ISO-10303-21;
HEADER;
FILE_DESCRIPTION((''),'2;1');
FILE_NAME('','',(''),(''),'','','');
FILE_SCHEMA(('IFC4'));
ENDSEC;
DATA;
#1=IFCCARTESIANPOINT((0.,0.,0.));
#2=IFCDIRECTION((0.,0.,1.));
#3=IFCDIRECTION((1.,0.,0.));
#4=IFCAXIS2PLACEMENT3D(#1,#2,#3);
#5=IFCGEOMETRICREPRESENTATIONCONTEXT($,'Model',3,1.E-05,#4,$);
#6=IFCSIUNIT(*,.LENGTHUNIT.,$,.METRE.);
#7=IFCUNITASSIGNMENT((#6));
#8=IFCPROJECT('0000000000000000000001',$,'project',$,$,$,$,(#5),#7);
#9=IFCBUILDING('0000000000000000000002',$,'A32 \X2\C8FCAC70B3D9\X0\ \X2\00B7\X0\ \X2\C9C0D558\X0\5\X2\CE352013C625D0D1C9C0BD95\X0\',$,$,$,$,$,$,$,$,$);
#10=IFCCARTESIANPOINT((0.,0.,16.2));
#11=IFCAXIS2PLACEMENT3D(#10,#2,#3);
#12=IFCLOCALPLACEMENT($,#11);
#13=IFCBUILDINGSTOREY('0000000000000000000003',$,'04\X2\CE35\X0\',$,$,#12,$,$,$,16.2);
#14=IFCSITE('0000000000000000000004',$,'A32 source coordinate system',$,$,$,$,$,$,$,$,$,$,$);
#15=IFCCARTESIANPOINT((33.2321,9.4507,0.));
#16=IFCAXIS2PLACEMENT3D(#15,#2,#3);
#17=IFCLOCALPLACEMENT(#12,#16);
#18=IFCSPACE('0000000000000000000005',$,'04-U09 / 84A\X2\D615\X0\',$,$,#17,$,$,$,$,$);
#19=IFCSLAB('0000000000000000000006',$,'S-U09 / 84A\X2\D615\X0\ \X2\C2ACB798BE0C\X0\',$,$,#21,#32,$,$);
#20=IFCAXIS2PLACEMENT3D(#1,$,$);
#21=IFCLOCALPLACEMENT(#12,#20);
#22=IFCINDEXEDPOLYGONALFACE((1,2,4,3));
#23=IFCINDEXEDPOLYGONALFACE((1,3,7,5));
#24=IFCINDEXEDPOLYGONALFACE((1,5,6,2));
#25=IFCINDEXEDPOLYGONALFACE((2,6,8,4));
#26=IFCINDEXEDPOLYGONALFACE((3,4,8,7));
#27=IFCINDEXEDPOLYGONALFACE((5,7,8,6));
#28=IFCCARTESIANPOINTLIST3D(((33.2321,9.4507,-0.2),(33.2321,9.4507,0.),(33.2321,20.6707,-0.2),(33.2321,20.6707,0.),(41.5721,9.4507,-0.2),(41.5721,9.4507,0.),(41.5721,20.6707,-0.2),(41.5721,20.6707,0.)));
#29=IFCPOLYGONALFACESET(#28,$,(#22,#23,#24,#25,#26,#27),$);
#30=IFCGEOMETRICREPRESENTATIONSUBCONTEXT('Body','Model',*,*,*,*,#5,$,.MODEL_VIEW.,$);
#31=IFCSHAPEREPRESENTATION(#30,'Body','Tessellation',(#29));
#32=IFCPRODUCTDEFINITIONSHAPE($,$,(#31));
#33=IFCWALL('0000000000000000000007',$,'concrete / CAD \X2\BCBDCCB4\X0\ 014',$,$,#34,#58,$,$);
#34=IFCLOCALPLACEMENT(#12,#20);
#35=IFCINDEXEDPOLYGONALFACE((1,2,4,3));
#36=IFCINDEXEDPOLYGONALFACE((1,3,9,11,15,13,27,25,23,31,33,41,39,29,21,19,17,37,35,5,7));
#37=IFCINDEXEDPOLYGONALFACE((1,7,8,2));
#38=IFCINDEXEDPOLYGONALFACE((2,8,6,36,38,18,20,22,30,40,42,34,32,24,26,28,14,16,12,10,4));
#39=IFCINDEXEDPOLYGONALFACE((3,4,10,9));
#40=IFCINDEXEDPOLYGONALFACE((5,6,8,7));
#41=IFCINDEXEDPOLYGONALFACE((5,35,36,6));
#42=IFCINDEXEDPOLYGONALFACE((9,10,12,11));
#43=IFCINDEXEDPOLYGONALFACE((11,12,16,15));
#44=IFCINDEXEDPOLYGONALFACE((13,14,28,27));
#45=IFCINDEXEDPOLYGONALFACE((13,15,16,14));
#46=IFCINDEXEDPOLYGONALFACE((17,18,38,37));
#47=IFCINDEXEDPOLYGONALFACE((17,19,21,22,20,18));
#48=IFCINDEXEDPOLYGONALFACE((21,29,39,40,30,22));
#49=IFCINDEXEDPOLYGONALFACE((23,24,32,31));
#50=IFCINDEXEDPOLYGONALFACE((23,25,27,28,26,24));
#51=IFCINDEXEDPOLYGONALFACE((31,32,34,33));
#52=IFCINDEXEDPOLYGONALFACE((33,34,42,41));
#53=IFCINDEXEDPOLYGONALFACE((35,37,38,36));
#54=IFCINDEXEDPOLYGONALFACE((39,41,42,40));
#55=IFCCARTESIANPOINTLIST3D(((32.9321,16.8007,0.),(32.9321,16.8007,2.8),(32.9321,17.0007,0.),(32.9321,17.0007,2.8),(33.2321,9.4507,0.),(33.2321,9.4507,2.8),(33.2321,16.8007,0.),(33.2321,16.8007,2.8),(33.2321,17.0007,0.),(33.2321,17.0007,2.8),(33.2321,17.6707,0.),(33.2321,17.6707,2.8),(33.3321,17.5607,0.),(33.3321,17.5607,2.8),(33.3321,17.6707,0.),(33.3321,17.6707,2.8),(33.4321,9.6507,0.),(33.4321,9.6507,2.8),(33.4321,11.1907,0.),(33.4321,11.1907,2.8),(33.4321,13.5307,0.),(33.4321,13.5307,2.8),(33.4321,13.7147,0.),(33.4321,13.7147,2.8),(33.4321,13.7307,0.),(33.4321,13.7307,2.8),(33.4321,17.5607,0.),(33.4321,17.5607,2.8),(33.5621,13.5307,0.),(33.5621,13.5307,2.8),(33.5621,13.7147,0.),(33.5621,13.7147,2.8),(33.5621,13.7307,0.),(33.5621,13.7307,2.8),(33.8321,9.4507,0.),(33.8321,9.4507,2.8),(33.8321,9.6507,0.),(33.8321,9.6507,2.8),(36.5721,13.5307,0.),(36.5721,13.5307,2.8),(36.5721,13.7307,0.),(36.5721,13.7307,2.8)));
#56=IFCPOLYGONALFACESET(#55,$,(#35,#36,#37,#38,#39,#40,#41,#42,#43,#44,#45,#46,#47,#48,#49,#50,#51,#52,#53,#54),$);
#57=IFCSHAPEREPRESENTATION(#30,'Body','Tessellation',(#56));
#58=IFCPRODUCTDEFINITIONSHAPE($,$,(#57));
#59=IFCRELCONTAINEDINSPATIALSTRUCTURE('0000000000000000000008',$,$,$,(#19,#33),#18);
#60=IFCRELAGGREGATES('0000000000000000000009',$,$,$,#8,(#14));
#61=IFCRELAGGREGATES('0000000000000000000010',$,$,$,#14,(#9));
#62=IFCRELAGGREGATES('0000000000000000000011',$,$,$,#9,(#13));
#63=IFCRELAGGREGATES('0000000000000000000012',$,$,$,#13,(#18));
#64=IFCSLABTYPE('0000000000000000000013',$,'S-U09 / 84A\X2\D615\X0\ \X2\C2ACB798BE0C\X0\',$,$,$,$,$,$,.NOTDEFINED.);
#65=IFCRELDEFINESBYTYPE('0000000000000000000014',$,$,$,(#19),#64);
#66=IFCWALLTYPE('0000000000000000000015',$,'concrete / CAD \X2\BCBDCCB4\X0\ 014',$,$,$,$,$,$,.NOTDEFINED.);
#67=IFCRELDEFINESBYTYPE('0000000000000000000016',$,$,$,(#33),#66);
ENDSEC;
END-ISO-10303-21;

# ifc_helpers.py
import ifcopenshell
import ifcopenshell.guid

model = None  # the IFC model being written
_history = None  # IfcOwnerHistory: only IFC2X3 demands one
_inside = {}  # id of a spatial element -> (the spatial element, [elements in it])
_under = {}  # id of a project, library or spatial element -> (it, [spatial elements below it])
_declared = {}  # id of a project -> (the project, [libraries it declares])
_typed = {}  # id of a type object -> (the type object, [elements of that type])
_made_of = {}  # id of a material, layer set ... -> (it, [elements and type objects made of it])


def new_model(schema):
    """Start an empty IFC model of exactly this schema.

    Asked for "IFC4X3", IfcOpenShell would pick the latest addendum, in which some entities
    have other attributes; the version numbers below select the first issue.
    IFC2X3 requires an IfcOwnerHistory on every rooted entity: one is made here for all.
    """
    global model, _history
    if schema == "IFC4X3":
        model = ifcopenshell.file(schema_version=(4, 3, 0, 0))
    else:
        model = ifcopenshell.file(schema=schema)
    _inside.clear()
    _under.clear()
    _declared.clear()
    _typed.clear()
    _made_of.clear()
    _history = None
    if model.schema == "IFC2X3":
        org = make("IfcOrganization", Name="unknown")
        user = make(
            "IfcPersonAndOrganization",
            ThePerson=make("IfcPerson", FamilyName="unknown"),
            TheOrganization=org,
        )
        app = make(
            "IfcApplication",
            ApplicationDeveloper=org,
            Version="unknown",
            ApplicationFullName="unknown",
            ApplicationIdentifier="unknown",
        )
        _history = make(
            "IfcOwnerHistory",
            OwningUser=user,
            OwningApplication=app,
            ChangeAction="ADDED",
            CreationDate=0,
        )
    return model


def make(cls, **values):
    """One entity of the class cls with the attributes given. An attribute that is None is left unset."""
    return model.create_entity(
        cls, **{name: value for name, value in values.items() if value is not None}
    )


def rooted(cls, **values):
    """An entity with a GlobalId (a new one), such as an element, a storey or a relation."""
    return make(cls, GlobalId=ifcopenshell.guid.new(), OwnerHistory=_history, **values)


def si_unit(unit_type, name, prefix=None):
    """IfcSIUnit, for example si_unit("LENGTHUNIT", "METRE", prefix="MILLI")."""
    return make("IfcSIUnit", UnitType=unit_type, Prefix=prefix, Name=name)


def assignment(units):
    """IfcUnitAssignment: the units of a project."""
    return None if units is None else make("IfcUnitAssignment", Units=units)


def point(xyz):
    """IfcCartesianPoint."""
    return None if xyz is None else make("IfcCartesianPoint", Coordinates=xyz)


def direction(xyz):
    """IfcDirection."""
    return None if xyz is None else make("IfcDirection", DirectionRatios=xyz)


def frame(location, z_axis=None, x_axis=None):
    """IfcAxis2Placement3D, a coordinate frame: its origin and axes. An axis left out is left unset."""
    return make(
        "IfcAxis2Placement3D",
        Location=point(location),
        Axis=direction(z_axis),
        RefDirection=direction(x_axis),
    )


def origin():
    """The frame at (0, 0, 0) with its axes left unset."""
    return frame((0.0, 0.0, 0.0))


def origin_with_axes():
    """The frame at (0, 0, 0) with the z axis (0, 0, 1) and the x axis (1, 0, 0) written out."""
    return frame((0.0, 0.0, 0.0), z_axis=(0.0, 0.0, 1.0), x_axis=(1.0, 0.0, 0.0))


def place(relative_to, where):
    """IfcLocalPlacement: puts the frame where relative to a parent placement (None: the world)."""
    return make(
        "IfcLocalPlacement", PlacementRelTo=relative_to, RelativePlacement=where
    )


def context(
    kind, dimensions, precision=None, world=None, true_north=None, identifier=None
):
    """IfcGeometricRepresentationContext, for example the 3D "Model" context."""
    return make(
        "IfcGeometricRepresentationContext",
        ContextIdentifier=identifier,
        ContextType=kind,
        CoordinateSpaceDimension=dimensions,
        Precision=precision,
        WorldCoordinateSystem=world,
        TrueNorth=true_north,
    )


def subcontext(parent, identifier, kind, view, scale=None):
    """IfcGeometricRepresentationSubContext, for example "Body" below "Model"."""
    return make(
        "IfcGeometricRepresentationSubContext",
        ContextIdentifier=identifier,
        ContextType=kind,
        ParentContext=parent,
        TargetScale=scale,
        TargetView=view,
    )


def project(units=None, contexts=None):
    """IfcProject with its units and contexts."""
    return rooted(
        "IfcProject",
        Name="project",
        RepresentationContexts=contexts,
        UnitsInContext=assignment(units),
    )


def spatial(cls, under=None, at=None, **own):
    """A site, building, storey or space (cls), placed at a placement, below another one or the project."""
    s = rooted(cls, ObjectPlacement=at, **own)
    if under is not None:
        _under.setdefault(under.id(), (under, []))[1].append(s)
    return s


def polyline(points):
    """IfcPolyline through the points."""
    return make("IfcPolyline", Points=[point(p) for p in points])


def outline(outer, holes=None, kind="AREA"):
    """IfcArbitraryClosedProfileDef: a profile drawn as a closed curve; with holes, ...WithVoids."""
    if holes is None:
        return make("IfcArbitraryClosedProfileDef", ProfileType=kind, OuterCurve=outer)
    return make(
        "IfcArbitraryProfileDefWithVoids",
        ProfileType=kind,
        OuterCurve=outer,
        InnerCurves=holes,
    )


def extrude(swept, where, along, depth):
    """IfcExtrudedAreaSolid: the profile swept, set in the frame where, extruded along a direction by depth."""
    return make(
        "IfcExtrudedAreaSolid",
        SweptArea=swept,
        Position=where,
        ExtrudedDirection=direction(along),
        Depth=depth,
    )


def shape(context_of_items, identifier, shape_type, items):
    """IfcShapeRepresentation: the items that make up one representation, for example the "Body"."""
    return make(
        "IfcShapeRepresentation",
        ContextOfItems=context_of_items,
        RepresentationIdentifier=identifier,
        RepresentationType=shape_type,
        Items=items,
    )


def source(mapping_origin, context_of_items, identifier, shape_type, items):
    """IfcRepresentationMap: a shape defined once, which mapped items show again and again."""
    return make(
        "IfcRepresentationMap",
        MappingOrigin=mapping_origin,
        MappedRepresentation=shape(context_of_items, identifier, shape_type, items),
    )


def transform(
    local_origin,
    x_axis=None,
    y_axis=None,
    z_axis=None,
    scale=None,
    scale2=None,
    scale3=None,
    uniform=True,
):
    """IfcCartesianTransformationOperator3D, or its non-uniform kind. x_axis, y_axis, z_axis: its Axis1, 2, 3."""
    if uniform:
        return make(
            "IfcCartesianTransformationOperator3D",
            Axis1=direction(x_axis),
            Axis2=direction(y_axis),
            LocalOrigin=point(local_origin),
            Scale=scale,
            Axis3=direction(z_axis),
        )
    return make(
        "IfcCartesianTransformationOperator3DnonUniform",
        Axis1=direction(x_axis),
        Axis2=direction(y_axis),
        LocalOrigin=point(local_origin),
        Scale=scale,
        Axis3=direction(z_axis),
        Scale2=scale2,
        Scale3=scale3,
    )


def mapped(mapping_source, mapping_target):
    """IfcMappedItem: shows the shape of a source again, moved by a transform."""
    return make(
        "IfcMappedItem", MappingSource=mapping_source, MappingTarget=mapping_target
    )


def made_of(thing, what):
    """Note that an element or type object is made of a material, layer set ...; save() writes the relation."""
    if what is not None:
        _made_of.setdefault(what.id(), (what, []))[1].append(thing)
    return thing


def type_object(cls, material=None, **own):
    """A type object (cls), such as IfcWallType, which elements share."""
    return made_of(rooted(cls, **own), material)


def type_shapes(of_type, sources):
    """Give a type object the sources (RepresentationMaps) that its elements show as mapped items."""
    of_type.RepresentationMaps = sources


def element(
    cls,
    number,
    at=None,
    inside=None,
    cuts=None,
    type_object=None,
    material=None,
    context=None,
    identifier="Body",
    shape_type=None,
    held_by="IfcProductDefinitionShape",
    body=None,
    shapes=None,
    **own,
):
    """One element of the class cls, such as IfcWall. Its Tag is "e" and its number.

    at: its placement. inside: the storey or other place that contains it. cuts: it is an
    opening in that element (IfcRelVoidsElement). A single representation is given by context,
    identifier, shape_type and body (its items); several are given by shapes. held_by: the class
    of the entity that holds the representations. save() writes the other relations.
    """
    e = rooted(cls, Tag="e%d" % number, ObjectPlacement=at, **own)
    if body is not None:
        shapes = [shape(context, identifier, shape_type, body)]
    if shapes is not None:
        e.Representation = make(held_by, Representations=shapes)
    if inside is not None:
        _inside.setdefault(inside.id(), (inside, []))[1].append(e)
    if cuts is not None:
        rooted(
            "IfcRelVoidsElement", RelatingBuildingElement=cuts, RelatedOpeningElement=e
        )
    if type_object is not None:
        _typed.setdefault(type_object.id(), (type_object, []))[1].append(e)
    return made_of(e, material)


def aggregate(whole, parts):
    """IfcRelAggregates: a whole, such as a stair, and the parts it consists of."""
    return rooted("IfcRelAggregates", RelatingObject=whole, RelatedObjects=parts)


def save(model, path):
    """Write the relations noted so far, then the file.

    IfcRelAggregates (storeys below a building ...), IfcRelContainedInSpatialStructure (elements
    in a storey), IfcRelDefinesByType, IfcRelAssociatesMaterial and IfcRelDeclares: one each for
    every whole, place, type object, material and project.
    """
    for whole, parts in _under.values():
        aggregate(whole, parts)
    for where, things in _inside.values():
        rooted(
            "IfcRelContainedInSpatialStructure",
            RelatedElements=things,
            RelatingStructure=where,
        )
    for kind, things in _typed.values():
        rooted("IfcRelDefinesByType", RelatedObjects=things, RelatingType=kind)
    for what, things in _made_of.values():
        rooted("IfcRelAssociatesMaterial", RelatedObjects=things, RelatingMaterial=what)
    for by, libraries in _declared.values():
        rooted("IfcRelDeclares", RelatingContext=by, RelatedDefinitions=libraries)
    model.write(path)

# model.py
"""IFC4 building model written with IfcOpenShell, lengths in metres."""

from ifc_helpers import new_model, si_unit, frame, origin, origin_with_axes, place, context, subcontext, project, spatial, polyline, outline, extrude, source, transform, mapped, type_object, type_shapes, element, save


model = new_model("IFC4")

# Units and contexts
model_context = context("Model", 3, precision=1e-05, world=origin_with_axes())
body_context = subcontext(model_context, "Body", "Model", "MODEL_VIEW")
ifc_project = project(units=[si_unit("LENGTHUNIT", "METRE")], contexts=[model_context])

# Site, building, storey, space
storey_placement = place(None, frame((0.0, 0.0, 16.2), z_axis=(0.0, 0.0, 1.0), x_axis=(1.0, 0.0, 0.0)))
space_placement = place(storey_placement, frame((33.2321, 9.4507, 0.0), z_axis=(0.0, 0.0, 1.0), x_axis=(1.0, 0.0, 0.0)))
site = spatial("IfcSite", under=ifc_project, Name="A32 source coordinate system")
building = spatial("IfcBuilding", under=site, Name="A32 주거동 · 지하5층–옥탑지붕")
storey = spatial("IfcBuildingStorey", under=building, at=storey_placement, Name="04층", Elevation=16.2)
space = spatial("IfcSpace", under=storey, at=space_placement, Name="04-U09 / 84A형")

# Slab
slab_type_1 = type_object("IfcSlabType", Name="S-U09 / 84A형 슬래브", PredefinedType="NOTDEFINED")
shared_shape_1 = source(origin(), body_context, "Body", "SweptSolid", [
    extrude(outline(polyline([(0.0, 11.22), (8.34, 11.22), (8.34, 0.0), (0.0, 0.0), (0.0, 11.22)])), frame((0.0, 0.0, -0.2)), (0.0, 0.0, 1.0), 0.2),
])
type_shapes(slab_type_1, [shared_shape_1])
slab_1_placement = place(space_placement, origin_with_axes())
element("IfcSlab", 1, at=slab_1_placement, inside=space, type_object=slab_type_1, Name="S-U09 / 84A형 슬래브", context=body_context, shape_type="MappedRepresentation", body=[
    mapped(shared_shape_1, transform((0.0, 0.0, 0.0), scale=1.0)),
])

# Wall
wall_type_1 = type_object("IfcWallType", Name="concrete / CAD 벽체 014", PredefinedType="NOTDEFINED")
shared_shape_2 = source(origin(), body_context, "Body", "SweptSolid", [
    extrude(outline(polyline([(3.34, 4.08), (0.33, 4.08), (0.2, 4.08), (0.2, 1.74), (0.2, 0.2), (0.6, 0.2), (0.6, 0.0), (0.0, 0.0), (0.0, 7.35), (-0.3, 7.35), (-0.3, 7.55), (0.0, 7.55), (0.0, 8.22), (0.1, 8.22), (0.1, 8.11), (0.2, 8.11), (0.2, 4.28), (0.2, 4.264), (0.33, 4.264), (0.33, 4.28), (3.34, 4.28), (3.34, 4.08)])), origin(), (0.0, 0.0, 1.0), 2.8),
])
type_shapes(wall_type_1, [shared_shape_2])
wall_1_placement = place(space_placement, origin_with_axes())
element("IfcWall", 2, at=wall_1_placement, inside=space, type_object=wall_type_1, Name="concrete / CAD 벽체 014", context=body_context, shape_type="MappedRepresentation", body=[
    mapped(shared_shape_2, transform((0.0, 0.0, 0.0), scale=1.0)),
])

save(model, "model.ifc")
